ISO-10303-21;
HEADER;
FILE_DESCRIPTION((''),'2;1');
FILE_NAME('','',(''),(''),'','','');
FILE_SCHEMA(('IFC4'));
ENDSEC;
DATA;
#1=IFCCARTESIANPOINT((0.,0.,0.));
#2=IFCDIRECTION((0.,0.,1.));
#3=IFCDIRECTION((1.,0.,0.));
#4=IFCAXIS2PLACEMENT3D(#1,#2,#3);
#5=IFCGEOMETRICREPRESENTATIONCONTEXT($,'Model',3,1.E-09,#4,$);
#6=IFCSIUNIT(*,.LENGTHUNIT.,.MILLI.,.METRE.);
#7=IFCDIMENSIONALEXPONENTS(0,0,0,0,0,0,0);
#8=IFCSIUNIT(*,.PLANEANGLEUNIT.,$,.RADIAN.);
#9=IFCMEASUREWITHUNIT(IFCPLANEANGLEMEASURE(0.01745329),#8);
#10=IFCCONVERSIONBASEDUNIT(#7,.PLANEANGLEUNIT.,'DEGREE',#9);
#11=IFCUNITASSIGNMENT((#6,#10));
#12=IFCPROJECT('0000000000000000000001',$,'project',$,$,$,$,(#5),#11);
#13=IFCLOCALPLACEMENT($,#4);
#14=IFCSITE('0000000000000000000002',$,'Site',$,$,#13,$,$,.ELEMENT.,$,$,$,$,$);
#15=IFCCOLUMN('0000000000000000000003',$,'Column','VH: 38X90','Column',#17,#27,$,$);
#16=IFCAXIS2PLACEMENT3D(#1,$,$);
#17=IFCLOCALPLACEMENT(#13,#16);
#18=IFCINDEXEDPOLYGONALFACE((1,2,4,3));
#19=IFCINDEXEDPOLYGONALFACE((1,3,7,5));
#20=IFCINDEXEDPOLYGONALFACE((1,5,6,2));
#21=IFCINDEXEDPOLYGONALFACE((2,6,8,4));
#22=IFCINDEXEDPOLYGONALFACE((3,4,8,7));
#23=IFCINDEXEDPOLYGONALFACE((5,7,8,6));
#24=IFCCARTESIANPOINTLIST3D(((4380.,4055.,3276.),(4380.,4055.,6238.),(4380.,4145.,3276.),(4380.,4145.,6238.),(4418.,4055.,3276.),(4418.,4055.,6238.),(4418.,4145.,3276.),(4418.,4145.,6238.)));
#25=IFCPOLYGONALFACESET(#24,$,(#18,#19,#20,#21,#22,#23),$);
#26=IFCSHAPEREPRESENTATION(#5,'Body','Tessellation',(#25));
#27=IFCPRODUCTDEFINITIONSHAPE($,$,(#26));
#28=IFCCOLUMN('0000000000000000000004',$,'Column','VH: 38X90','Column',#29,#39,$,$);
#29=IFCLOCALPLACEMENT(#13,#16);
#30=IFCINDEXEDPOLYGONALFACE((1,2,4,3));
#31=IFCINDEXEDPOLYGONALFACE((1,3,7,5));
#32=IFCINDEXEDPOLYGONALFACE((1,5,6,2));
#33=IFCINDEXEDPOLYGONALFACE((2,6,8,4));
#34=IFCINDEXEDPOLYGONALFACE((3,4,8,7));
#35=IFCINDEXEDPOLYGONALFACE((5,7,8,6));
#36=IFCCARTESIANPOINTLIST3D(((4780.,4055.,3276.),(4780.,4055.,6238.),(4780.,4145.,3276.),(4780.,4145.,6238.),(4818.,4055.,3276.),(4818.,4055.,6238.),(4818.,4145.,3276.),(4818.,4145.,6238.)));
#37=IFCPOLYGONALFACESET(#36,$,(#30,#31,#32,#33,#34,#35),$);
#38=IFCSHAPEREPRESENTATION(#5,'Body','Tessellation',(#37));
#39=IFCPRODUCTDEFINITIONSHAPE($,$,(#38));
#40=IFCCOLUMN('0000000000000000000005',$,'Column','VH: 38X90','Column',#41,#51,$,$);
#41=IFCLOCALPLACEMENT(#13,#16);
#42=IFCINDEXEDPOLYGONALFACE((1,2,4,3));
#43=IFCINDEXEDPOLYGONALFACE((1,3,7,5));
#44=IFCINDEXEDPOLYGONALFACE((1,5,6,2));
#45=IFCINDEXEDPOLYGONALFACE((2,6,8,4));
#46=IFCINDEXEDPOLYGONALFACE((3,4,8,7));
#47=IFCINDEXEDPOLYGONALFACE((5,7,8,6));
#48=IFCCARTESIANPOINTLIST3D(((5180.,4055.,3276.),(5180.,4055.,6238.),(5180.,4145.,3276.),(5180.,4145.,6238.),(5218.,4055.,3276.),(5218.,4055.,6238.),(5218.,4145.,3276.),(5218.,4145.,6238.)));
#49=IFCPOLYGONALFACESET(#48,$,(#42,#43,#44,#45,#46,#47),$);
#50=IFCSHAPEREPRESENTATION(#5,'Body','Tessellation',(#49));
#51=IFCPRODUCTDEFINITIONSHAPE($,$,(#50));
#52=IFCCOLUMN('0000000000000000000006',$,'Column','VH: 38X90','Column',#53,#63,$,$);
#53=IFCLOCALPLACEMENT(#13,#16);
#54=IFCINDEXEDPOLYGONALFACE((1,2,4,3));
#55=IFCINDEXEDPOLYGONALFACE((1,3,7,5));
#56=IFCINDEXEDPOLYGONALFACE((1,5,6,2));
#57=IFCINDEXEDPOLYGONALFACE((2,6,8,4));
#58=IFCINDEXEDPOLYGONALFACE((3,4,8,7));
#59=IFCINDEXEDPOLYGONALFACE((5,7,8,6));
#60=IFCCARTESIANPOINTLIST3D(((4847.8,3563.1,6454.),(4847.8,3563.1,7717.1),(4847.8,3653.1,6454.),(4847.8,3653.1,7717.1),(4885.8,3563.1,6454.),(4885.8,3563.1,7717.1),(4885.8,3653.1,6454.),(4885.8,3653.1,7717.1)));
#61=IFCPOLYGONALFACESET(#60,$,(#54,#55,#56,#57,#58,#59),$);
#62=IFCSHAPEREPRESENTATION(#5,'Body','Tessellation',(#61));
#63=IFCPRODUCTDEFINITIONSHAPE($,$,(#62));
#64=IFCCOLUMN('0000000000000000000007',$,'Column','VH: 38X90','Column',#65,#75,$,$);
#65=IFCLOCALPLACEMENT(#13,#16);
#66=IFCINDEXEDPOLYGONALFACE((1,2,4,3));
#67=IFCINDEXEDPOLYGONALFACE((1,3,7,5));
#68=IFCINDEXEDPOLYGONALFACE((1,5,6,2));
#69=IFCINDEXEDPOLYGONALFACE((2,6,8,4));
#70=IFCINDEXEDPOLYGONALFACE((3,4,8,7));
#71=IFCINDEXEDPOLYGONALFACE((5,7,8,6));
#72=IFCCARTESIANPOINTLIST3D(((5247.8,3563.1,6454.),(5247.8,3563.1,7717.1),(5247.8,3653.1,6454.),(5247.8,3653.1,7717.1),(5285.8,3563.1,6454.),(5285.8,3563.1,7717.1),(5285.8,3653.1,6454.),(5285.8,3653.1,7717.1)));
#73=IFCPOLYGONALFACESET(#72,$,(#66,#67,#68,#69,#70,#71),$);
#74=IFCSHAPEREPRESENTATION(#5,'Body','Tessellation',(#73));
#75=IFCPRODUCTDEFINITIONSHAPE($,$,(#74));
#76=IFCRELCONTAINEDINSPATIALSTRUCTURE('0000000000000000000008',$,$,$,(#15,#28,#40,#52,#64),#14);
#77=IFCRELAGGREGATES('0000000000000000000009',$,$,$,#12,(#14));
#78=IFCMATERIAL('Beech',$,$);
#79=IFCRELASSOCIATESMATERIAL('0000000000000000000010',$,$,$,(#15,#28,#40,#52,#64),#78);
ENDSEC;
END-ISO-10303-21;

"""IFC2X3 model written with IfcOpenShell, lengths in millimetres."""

from ifc_helpers import new_model, entity, si_unit, converted_unit, frame, origin, origin_with_axes, origin_2d, place, context, project, spatial, rectangle, extrude, clip, halfspace, material, element, save


model = new_model("IFC2X3")

# Units and contexts
model_context = context("Model", 3, precision=1e-09, world=origin_with_axes())
ifc_project = project(units=[si_unit("LENGTHUNIT", "METRE", prefix="MILLI"), converted_unit("PLANEANGLEUNIT", "DEGREE", entity("IfcPlaneAngleMeasure", 0.01745329), si_unit("PLANEANGLEUNIT", "RADIAN"), dimensions=[0, 0, 0, 0, 0, 0, 0])], contexts=[model_context])

# Site
site_placement = place(None, origin_with_axes())
site = spatial("IfcSite", under=ifc_project, at=site_placement, Name="Site", CompositionType="ELEMENT")

# Columns
ifc_material = material(Name="Beech")
for number, where, z_axis, x_axis, name in (
    (1, (4399.0, 4100.0, 3276.0), (0.0, 0.0, -1.0), (-1.0, 0.0, 0.0), "Column"),
    (2, (4799.0, 4100.0, 3276.0), (0.0, 0.0, -1.0), (-1.0, 0.0, 0.0), "Column"),
    (3, (5199.0, 4100.0, 3276.0), (0.0, 0.0, -1.0), (-1.0, 0.0, 0.0), "Column"),
):
    element("IfcColumn", number, at=place(None, frame(where, z_axis=z_axis, x_axis=x_axis)), inside=site, material=ifc_material, Name=name, Description="VH: 38X90", ObjectType="Column", context=model_context, shape_type="SweptSolid", body=[
        extrude(rectangle(XDim=38.0, YDim=90.0, at=origin_2d()), origin(), (0.0, 0.0, -1.0), 2962.0),
    ])
column_1_placement = place(None, frame((4866.8, 3608.1, 6454.0), z_axis=(0.0, 0.0, -1.0), x_axis=(-1.0, 0.0, 0.0)))
element("IfcColumn", 4, at=column_1_placement, inside=site, material=ifc_material, Name="Column", Description="VH: 38X90", ObjectType="Column", context=model_context, shape_type="Clipping", body=[
    clip(extrude(rectangle(XDim=38.0, YDim=90.0, at=origin_2d()), origin(), (0.0, 0.0, -1.0), 1493.8), halfspace(frame((4866.8, -3608.1, -1263.1), z_axis=(0.0, 0.0, 1.0), x_axis=(1.0, 0.0, 0.0)), True)),
])
column_2_placement = place(None, frame((5266.8, 3608.1, 6454.0), z_axis=(0.0, 0.0, -1.0), x_axis=(-1.0, 0.0, 0.0)))
element("IfcColumn", 5, at=column_2_placement, inside=site, material=ifc_material, Name="Column", Description="VH: 38X90", ObjectType="Column", context=model_context, shape_type="Clipping", body=[
    clip(extrude(rectangle(XDim=38.0, YDim=90.0, at=origin_2d()), origin(), (0.0, 0.0, -1.0), 1493.8), halfspace(frame((5266.8, -3608.1, -1263.1), z_axis=(0.0, 0.0, 1.0), x_axis=(1.0, 0.0, 0.0)), True)),
])

save(model, "model.ifc")
